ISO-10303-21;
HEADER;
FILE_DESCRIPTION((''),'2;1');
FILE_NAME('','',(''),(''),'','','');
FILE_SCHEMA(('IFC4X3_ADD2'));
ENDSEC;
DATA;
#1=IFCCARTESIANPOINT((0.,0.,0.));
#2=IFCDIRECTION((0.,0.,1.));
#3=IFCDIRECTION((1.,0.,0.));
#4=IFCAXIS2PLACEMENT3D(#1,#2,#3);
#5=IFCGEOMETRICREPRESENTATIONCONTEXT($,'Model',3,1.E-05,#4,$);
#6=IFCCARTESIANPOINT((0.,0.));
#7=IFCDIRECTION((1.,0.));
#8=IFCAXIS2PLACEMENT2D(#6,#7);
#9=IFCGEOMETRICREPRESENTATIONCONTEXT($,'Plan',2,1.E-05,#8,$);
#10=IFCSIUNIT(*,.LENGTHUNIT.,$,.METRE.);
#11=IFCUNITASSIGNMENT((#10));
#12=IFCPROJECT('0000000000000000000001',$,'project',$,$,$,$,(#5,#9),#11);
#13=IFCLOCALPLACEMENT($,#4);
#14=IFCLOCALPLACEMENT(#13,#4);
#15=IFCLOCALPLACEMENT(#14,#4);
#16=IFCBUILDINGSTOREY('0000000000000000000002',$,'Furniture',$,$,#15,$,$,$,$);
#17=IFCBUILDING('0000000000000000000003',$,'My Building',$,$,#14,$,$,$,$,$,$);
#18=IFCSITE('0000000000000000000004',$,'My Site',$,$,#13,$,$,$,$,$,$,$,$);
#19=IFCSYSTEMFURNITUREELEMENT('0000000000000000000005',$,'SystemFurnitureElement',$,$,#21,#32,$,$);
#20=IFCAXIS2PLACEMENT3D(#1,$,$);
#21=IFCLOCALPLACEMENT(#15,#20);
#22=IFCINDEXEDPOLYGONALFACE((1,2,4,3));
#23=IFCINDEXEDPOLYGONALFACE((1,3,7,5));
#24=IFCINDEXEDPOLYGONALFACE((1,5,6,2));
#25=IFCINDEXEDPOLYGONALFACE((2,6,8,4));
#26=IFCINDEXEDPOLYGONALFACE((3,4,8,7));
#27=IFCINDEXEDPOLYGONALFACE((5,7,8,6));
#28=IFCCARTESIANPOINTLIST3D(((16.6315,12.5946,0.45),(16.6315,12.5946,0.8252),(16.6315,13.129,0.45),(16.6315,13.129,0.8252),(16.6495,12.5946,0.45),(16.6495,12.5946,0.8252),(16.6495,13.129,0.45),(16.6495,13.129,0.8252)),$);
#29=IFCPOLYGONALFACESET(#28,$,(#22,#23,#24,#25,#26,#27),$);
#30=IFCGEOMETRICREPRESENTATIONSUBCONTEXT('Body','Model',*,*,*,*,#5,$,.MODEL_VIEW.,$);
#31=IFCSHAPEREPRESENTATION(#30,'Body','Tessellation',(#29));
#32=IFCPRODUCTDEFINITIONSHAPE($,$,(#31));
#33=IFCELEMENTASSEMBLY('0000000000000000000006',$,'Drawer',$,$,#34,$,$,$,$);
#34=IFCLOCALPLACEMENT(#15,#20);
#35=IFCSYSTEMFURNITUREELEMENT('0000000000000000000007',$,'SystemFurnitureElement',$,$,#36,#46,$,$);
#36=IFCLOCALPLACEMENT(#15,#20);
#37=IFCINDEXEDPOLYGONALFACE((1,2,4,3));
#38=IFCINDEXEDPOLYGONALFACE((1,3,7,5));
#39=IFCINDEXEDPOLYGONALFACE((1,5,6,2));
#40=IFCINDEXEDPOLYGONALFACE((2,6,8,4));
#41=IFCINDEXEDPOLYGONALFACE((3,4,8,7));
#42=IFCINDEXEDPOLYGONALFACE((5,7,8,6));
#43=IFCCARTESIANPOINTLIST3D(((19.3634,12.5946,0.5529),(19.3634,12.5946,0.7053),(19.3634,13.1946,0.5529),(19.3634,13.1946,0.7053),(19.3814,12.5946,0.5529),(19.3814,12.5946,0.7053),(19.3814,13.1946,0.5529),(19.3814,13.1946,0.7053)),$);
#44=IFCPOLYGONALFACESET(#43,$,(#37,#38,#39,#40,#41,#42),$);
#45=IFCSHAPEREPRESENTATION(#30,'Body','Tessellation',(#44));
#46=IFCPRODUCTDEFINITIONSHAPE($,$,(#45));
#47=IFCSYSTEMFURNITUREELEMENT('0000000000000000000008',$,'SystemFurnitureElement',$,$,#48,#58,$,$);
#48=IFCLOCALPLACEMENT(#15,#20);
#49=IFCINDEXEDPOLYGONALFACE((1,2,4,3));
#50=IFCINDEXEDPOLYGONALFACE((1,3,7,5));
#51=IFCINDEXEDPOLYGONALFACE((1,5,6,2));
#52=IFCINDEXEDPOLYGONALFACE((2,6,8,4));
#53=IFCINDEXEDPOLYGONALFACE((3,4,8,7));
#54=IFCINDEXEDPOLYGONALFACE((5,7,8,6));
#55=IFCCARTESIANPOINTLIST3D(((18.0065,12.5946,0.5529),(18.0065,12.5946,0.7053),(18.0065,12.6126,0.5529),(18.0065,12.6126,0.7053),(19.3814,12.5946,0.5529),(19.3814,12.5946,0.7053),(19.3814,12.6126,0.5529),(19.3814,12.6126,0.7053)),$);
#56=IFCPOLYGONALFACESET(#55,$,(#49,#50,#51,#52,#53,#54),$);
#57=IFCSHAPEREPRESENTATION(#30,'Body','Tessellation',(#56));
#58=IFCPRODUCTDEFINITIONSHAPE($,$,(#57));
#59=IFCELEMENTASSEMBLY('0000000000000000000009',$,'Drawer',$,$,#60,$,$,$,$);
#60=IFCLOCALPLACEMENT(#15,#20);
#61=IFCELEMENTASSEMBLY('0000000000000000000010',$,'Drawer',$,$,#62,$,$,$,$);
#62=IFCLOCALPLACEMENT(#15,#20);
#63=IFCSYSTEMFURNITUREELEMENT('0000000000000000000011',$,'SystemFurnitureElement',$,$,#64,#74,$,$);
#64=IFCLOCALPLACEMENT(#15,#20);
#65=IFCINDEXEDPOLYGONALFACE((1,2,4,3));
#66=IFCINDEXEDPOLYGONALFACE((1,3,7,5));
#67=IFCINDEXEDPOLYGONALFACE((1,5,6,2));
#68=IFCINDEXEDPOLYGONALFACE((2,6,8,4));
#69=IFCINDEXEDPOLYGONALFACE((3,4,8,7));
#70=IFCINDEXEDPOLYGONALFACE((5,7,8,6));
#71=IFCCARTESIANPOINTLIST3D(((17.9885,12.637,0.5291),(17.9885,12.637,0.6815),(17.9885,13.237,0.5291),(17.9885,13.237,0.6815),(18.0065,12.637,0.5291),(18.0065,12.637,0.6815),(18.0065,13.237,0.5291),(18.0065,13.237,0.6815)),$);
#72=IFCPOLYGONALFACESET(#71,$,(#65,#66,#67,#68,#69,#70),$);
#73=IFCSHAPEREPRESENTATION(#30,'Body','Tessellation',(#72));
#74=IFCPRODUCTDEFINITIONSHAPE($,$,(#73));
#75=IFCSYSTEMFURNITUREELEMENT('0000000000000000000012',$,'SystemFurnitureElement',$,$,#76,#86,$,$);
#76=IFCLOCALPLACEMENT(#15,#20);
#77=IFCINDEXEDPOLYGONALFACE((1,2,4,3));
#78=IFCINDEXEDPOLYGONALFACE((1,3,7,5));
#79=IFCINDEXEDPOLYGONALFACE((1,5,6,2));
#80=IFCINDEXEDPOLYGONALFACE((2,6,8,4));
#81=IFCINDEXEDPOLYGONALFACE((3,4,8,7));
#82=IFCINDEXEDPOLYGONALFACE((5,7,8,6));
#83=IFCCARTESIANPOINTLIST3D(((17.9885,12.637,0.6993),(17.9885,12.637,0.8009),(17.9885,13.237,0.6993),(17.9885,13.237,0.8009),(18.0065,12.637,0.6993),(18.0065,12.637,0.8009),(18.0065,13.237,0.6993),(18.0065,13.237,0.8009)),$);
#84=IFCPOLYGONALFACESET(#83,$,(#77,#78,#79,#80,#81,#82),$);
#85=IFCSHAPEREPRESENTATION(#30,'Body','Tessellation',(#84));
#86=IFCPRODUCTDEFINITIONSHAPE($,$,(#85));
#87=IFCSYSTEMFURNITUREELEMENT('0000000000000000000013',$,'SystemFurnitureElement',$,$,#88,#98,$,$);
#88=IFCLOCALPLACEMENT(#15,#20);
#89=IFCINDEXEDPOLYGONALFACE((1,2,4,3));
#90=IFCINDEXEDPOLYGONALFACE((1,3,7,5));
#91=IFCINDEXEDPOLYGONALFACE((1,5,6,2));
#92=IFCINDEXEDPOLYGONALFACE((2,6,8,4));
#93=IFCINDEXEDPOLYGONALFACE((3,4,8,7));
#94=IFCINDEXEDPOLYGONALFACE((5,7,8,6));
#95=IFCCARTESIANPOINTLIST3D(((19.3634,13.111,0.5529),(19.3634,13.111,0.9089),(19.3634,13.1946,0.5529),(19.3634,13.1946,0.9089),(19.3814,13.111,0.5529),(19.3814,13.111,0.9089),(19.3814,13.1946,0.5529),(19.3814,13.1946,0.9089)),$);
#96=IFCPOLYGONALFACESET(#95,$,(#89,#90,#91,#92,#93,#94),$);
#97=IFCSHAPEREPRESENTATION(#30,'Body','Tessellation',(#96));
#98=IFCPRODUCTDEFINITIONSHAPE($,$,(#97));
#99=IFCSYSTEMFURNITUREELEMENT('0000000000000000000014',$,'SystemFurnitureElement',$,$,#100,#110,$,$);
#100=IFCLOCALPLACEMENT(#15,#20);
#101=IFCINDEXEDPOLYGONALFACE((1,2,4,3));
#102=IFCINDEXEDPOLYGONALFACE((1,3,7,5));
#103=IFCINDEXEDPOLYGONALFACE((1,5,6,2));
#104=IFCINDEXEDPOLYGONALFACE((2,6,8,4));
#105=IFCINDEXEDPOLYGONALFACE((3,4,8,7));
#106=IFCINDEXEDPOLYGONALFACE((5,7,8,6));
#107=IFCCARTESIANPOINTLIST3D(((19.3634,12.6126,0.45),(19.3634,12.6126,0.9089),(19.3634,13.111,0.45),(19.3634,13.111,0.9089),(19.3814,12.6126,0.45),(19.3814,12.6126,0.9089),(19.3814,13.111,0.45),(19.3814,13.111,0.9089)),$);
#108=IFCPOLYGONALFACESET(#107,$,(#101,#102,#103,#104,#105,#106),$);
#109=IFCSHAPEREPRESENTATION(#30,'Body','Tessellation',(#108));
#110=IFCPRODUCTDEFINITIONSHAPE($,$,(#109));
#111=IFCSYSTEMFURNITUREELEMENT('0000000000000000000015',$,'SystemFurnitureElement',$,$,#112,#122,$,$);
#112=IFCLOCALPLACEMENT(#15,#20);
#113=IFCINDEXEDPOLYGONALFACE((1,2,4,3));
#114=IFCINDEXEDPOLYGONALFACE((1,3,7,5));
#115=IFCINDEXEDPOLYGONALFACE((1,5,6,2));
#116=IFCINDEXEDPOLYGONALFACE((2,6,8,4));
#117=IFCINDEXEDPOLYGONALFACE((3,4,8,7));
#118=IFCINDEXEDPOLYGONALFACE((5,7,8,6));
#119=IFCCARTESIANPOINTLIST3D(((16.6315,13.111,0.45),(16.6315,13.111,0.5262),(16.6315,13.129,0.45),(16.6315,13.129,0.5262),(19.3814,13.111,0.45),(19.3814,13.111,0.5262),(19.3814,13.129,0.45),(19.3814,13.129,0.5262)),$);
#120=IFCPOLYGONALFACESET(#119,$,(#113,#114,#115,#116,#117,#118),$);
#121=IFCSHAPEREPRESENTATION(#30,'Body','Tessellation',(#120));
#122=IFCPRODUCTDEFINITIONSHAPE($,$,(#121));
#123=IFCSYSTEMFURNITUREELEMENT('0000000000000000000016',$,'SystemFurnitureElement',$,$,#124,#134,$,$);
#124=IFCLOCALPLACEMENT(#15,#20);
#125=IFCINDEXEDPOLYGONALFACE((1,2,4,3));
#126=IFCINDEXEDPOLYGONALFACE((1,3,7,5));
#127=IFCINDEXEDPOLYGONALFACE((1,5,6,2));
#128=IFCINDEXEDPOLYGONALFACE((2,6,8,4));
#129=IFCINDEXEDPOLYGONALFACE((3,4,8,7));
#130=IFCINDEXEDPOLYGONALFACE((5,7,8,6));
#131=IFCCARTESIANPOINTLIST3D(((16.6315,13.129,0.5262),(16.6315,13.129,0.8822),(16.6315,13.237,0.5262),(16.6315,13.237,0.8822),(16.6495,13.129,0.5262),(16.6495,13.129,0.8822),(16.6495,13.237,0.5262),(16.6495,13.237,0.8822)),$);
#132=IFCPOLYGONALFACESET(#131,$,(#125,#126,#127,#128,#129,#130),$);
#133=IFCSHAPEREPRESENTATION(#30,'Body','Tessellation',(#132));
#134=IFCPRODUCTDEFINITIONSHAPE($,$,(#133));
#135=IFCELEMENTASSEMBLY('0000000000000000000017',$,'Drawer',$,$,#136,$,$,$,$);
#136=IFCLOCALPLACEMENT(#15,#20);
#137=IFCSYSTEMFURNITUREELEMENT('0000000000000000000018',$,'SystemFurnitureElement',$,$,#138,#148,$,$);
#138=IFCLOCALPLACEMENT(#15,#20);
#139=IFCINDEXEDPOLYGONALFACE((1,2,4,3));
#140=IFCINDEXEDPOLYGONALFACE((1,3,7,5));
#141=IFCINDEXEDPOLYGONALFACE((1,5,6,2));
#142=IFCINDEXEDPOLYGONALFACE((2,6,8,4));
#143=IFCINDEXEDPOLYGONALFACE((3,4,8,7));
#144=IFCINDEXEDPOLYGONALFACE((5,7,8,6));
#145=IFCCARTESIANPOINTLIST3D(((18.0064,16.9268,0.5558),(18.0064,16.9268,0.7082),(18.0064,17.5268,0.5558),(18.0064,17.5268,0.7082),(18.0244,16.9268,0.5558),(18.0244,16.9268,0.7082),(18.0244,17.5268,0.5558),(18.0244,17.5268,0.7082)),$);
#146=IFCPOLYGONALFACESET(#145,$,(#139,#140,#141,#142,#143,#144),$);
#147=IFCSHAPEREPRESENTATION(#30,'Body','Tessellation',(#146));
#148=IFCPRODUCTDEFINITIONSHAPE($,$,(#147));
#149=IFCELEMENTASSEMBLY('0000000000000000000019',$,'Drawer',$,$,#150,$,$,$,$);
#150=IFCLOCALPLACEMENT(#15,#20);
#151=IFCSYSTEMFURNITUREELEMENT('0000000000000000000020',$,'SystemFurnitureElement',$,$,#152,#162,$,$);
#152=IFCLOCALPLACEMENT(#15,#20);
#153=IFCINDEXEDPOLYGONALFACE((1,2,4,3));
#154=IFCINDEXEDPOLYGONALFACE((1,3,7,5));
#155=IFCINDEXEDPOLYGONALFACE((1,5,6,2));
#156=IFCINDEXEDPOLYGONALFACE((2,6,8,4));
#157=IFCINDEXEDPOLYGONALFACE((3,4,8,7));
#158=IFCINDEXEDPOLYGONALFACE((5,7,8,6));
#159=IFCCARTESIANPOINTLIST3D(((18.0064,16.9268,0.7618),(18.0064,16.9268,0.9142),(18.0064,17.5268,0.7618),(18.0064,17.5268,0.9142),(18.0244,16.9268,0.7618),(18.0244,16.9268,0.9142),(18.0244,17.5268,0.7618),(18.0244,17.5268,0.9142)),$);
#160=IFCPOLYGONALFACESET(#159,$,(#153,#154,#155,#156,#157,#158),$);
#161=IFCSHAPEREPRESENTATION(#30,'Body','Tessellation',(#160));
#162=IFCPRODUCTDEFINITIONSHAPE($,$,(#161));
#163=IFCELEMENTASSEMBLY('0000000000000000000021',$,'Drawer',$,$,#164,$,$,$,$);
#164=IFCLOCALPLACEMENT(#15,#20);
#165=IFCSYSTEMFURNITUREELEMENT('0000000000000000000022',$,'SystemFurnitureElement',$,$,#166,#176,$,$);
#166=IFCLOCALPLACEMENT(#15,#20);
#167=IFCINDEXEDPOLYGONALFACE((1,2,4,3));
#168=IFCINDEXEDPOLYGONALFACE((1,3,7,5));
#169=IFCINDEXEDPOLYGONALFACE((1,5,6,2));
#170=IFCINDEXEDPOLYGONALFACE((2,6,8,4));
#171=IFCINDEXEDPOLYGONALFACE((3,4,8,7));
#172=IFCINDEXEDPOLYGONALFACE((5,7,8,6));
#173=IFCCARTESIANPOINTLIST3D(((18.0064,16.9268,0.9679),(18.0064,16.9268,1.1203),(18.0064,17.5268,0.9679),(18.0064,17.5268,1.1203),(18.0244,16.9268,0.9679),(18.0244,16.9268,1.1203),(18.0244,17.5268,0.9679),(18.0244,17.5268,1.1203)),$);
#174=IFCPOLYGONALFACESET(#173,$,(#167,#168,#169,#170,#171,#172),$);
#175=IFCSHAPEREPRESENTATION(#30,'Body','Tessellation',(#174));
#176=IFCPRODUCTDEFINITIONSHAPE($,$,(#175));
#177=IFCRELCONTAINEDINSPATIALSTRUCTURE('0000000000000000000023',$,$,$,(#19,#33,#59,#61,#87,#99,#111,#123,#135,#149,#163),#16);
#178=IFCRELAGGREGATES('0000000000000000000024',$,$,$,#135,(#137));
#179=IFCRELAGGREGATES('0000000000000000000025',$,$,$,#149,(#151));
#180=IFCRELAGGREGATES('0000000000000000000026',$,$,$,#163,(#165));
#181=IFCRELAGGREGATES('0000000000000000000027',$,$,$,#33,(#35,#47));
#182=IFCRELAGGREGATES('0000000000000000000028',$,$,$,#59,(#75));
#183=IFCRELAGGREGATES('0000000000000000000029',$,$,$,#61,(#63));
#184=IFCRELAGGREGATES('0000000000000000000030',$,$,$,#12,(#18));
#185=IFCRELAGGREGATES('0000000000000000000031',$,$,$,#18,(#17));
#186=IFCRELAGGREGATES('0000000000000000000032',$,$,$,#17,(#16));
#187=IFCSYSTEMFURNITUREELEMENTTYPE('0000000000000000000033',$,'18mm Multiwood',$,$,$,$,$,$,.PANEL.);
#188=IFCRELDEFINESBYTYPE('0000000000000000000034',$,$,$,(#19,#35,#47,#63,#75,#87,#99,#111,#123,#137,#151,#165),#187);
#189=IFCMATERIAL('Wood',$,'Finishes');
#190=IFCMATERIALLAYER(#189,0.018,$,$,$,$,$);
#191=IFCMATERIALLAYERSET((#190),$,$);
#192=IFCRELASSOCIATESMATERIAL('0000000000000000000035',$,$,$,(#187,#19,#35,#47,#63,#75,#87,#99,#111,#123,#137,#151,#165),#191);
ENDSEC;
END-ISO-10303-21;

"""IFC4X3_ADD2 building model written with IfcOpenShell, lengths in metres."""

from ifc_helpers import new_model, si_unit, frame, origin_with_axes, origin_2d_with_axis, place, context, subcontext, project, spatial, line, indexed_curve, outline, extrude, material, layer, layer_set, layer_usage, type_object, element, aggregate, save


model = new_model("IFC4X3_ADD2")

# Units and contexts
model_context = context("Model", 3, precision=1e-05, world=origin_with_axes())
plan_context = context("Plan", 2, precision=1e-05, world=origin_2d_with_axis())
body_context = subcontext(model_context, "Body", "Model", "MODEL_VIEW")
ifc_project = project(units=[si_unit("LENGTHUNIT", "METRE")], contexts=[model_context, plan_context])

# Site, building, storey
site_placement = place(None, origin_with_axes())
site = spatial("IfcSite", under=ifc_project, at=site_placement, Name="My Site")
building_placement = place(site_placement, origin_with_axes())
building = spatial("IfcBuilding", under=site, at=building_placement, Name="My Building")
storey_placement = place(building_placement, origin_with_axes())
storey = spatial("IfcBuildingStorey", under=building, at=storey_placement, Name="Furniture")

# System furniture element
ifc_material_1 = material(Name="Wood", Category="Finishes")
ifc_layer_1 = layer(ifc_material_1, 0.018)
ifc_layer_set_1 = layer_set([ifc_layer_1])
ifc_layer_usage_1 = layer_usage(ifc_layer_set_1, "AXIS2", "POSITIVE", 0.0)
system_furniture_element_type_1 = type_object("IfcSystemFurnitureElementType", Name="18mm Multiwood", PredefinedType="PANEL", material=ifc_layer_set_1)
system_furniture_element_1_placement = place(storey_placement, frame((16.6495, 12.5946, 0.45), z_axis=(0.0, 0.0, 1.0), x_axis=(0.0, 1.0, 0.0)))
element("IfcSystemFurnitureElement", 1, at=system_furniture_element_1_placement, inside=storey, type_object=system_furniture_element_type_1, material=ifc_layer_usage_1, Name="SystemFurnitureElement", context=body_context, shape_type="SweptSolid", body=[
    extrude(outline(indexed_curve([(0.0, 0.0), (0.0, 0.018), (0.5344, 0.018), (0.5344, 0.0)], segments=[line(1, 2, 3, 4, 1)])), origin_with_axes(), (0.0, 0.0, 1.0), 0.3752),
])

# Element assembly, system furniture element
assembly_1_placement = place(storey_placement, frame((19.3814, 13.2126, 0.5529), z_axis=(0.0, 0.0, 1.0), x_axis=(1.0, 0.0, 0.0)))
assembly_1 = element("IfcElementAssembly", 2, at=assembly_1_placement, inside=storey, Name="Drawer")
ifc_layer_usage_2 = layer_usage(ifc_layer_set_1, "AXIS2", "POSITIVE", 0.0)
system_furniture_element_2_placement = place(assembly_1_placement, frame((-0.018, -0.018, 0.0), z_axis=(0.0, 0.0, 1.0), x_axis=(-0.000001, -1.0, 0.0)))
system_furniture_element_2 = element("IfcSystemFurnitureElement", 3, at=system_furniture_element_2_placement, type_object=system_furniture_element_type_1, material=ifc_layer_usage_2, Name="SystemFurnitureElement", context=body_context, shape_type="SweptSolid", body=[
    extrude(outline(indexed_curve([(0.0, 0.0), (0.0, 0.018), (0.6, 0.018), (0.6, 0.0)], segments=[line(1, 2, 3, 4, 1)])), origin_with_axes(), (0.0, 0.0, 1.0), 0.1524),
])

# System furniture element
ifc_layer_usage_3 = layer_usage(ifc_layer_set_1, "AXIS2", "POSITIVE", 0.0)
system_furniture_element_3_placement = place(assembly_1_placement, frame((-1.375, -0.618, 0.0), z_axis=(0.0, 0.0, 1.0), x_axis=(1.0, 0.0, 0.0)))
system_furniture_element_3 = element("IfcSystemFurnitureElement", 4, at=system_furniture_element_3_placement, type_object=system_furniture_element_type_1, material=ifc_layer_usage_3, Name="SystemFurnitureElement", context=body_context, shape_type="SweptSolid", body=[
    extrude(outline(indexed_curve([(0.0, 0.0), (0.0, 0.018), (1.375, 0.018), (1.375, 0.0)], segments=[line(1, 2, 3, 4, 1)])), origin_with_axes(), (0.0, 0.0, 1.0), 0.1524),
])

# Element assemblies, system furniture element
assembly_2_placement = place(storey_placement, frame((18.0065, 13.255, 0.6964), z_axis=(0.0, 0.0, 1.0), x_axis=(1.0, 0.0, 0.0)))
assembly_2 = element("IfcElementAssembly", 5, at=assembly_2_placement, inside=storey, Name="Drawer")
assembly_3_placement = place(storey_placement, frame((18.0065, 13.255, 0.5262), z_axis=(0.0, 0.0, 1.0), x_axis=(1.0, 0.0, 0.0)))
assembly_3 = element("IfcElementAssembly", 6, at=assembly_3_placement, inside=storey, Name="Drawer")
ifc_layer_usage_4 = layer_usage(ifc_layer_set_1, "AXIS2", "POSITIVE", 0.0)
system_furniture_element_4_placement = place(assembly_3_placement, frame((-0.018, -0.018, 0.0029), z_axis=(0.0, 0.0, 1.0), x_axis=(-0.000001, -1.0, 0.0)))
system_furniture_element_4 = element("IfcSystemFurnitureElement", 7, at=system_furniture_element_4_placement, type_object=system_furniture_element_type_1, material=ifc_layer_usage_4, Name="SystemFurnitureElement", context=body_context, shape_type="SweptSolid", body=[
    extrude(outline(indexed_curve([(0.0, 0.0), (0.0, 0.018), (0.6, 0.018), (0.6, 0.0)], segments=[line(1, 2, 3, 4, 1)])), origin_with_axes(), (0.0, 0.0, 1.0), 0.1524),
])

# System furniture element
ifc_layer_usage_5 = layer_usage(ifc_layer_set_1, "AXIS2", "POSITIVE", 0.0)
system_furniture_element_5_placement = place(assembly_2_placement, frame((-0.018, -0.018, 0.0029), z_axis=(0.0, 0.0, 1.0), x_axis=(-0.000001, -1.0, 0.0)))
system_furniture_element_5 = element("IfcSystemFurnitureElement", 8, at=system_furniture_element_5_placement, type_object=system_furniture_element_type_1, material=ifc_layer_usage_5, Name="SystemFurnitureElement", context=body_context, shape_type="SweptSolid", body=[
    extrude(outline(indexed_curve([(0.0, 0.0), (0.0, 0.018), (0.6, 0.018), (0.6, 0.0)], segments=[line(1, 2, 3, 4, 1)])), origin_with_axes(), (0.0, 0.0, 1.0), 0.1016),
])

# System furniture elements
ifc_layer_usage_6 = layer_usage(ifc_layer_set_1, "AXIS2", "POSITIVE", 0.0)
system_furniture_element_6_placement = place(storey_placement, frame((19.3814, 13.111, 0.5529), z_axis=(0.0, 0.0, 1.0), x_axis=(0.0, 1.0, 0.0)))
element("IfcSystemFurnitureElement", 9, at=system_furniture_element_6_placement, inside=storey, type_object=system_furniture_element_type_1, material=ifc_layer_usage_6, Name="SystemFurnitureElement", context=body_context, shape_type="SweptSolid", body=[
    extrude(outline(indexed_curve([(0.0, 0.0), (0.0, 0.018), (0.0836, 0.018), (0.0836, 0.0)], segments=[line(1, 2, 3, 4, 1)])), origin_with_axes(), (0.0, 0.0, 1.0), 0.356),
])
ifc_layer_usage_7 = layer_usage(ifc_layer_set_1, "AXIS2", "POSITIVE", 0.0)
system_furniture_element_7_placement = place(storey_placement, frame((19.3814, 12.6126, 0.45), z_axis=(0.0, 0.0, 1.0), x_axis=(0.0, 1.0, 0.0)))
element("IfcSystemFurnitureElement", 10, at=system_furniture_element_7_placement, inside=storey, type_object=system_furniture_element_type_1, material=ifc_layer_usage_7, Name="SystemFurnitureElement", context=body_context, shape_type="SweptSolid", body=[
    extrude(outline(indexed_curve([(0.0, 0.0), (0.0, 0.018), (0.4984, 0.018), (0.4984, 0.0)], segments=[line(1, 2, 3, 4, 1)])), origin_with_axes(), (0.0, 0.0, 1.0), 0.4589),
])
ifc_layer_usage_8 = layer_usage(ifc_layer_set_1, "AXIS2", "POSITIVE", 0.0)
system_furniture_element_8_placement = place(storey_placement, frame((19.3814, 13.129, 0.45), z_axis=(0.0, 0.0, 1.0), x_axis=(-1.0, 0.000001, 0.0)))
element("IfcSystemFurnitureElement", 11, at=system_furniture_element_8_placement, inside=storey, type_object=system_furniture_element_type_1, material=ifc_layer_usage_8, Name="SystemFurnitureElement", context=body_context, shape_type="SweptSolid", body=[
    extrude(outline(indexed_curve([(0.0, 0.0), (0.0, 0.018), (2.75, 0.018), (2.75, 0.0)], segments=[line(1, 2, 3, 4, 1)])), origin_with_axes(), (0.0, 0.0, 1.0), 0.0762),
])
ifc_layer_usage_9 = layer_usage(ifc_layer_set_1, "AXIS2", "POSITIVE", 0.0)
system_furniture_element_9_placement = place(storey_placement, frame((16.6495, 13.129, 0.5262), z_axis=(0.0, 0.0, 1.0), x_axis=(0.000001, 1.0, 0.0)))
element("IfcSystemFurnitureElement", 12, at=system_furniture_element_9_placement, inside=storey, type_object=system_furniture_element_type_1, material=ifc_layer_usage_9, Name="SystemFurnitureElement", context=body_context, shape_type="SweptSolid", body=[
    extrude(outline(indexed_curve([(0.0, 0.0), (0.0, 0.018), (0.108, 0.018), (0.108, 0.0)], segments=[line(1, 2, 3, 4, 1)])), origin_with_axes(), (0.0, 0.0, 1.0), 0.356),
])

# Element assemblies, system furniture elements
assembly_4_placement = place(storey_placement, frame((18.0064, 16.9088, 0.5558), z_axis=(0.0, 0.0, 1.0), x_axis=(-1.0, 0.0, 0.0)))
assembly_4 = element("IfcElementAssembly", 13, at=assembly_4_placement, inside=storey, Name="Drawer")
ifc_layer_usage_10 = layer_usage(ifc_layer_set_1, "AXIS2", "POSITIVE", 0.0)
system_furniture_element_10_placement = place(assembly_4_placement, frame((-0.018, -0.018, 0.0), z_axis=(0.0, 0.0, 1.0), x_axis=(-0.000001, -1.0, 0.0)))
system_furniture_element_10 = element("IfcSystemFurnitureElement", 14, at=system_furniture_element_10_placement, type_object=system_furniture_element_type_1, material=ifc_layer_usage_10, Name="SystemFurnitureElement", context=body_context, shape_type="SweptSolid", body=[
    extrude(outline(indexed_curve([(0.0, 0.0), (0.0, 0.018), (0.6, 0.018), (0.6, 0.0)], segments=[line(1, 2, 3, 4, 1)])), origin_with_axes(), (0.0, 0.0, 1.0), 0.1524),
])
aggregate(assembly_4, [system_furniture_element_10])
assembly_5_placement = place(storey_placement, frame((18.0064, 16.9088, 0.7618), z_axis=(0.0, 0.0, 1.0), x_axis=(-1.0, 0.0, 0.0)))
assembly_5 = element("IfcElementAssembly", 15, at=assembly_5_placement, inside=storey, Name="Drawer")
ifc_layer_usage_11 = layer_usage(ifc_layer_set_1, "AXIS2", "POSITIVE", 0.0)
system_furniture_element_11_placement = place(assembly_5_placement, frame((-0.018, -0.018, 0.0), z_axis=(0.0, 0.0, 1.0), x_axis=(-0.000001, -1.0, 0.0)))
system_furniture_element_11 = element("IfcSystemFurnitureElement", 16, at=system_furniture_element_11_placement, type_object=system_furniture_element_type_1, material=ifc_layer_usage_11, Name="SystemFurnitureElement", context=body_context, shape_type="SweptSolid", body=[
    extrude(outline(indexed_curve([(0.0, 0.0), (0.0, 0.018), (0.6, 0.018), (0.6, 0.0)], segments=[line(1, 2, 3, 4, 1)])), origin_with_axes(), (0.0, 0.0, 1.0), 0.1524),
])
aggregate(assembly_5, [system_furniture_element_11])
assembly_6_placement = place(storey_placement, frame((18.0064, 16.9088, 0.9679), z_axis=(0.0, 0.0, 1.0), x_axis=(-1.0, 0.0, 0.0)))
assembly_6 = element("IfcElementAssembly", 17, at=assembly_6_placement, inside=storey, Name="Drawer")
ifc_layer_usage_12 = layer_usage(ifc_layer_set_1, "AXIS2", "POSITIVE", 0.0)
system_furniture_element_12_placement = place(assembly_6_placement, frame((-0.018, -0.018, 0.0), z_axis=(0.0, 0.0, 1.0), x_axis=(-0.000001, -1.0, 0.0)))
system_furniture_element_12 = element("IfcSystemFurnitureElement", 18, at=system_furniture_element_12_placement, type_object=system_furniture_element_type_1, material=ifc_layer_usage_12, Name="SystemFurnitureElement", context=body_context, shape_type="SweptSolid", body=[
    extrude(outline(indexed_curve([(0.0, 0.0), (0.0, 0.018), (0.6, 0.018), (0.6, 0.0)], segments=[line(1, 2, 3, 4, 1)])), origin_with_axes(), (0.0, 0.0, 1.0), 0.1524),
])
aggregate(assembly_6, [system_furniture_element_12])

aggregate(assembly_1, [system_furniture_element_2, system_furniture_element_3])
aggregate(assembly_2, [system_furniture_element_5])
aggregate(assembly_3, [system_furniture_element_4])

save(model, "model.ifc")
